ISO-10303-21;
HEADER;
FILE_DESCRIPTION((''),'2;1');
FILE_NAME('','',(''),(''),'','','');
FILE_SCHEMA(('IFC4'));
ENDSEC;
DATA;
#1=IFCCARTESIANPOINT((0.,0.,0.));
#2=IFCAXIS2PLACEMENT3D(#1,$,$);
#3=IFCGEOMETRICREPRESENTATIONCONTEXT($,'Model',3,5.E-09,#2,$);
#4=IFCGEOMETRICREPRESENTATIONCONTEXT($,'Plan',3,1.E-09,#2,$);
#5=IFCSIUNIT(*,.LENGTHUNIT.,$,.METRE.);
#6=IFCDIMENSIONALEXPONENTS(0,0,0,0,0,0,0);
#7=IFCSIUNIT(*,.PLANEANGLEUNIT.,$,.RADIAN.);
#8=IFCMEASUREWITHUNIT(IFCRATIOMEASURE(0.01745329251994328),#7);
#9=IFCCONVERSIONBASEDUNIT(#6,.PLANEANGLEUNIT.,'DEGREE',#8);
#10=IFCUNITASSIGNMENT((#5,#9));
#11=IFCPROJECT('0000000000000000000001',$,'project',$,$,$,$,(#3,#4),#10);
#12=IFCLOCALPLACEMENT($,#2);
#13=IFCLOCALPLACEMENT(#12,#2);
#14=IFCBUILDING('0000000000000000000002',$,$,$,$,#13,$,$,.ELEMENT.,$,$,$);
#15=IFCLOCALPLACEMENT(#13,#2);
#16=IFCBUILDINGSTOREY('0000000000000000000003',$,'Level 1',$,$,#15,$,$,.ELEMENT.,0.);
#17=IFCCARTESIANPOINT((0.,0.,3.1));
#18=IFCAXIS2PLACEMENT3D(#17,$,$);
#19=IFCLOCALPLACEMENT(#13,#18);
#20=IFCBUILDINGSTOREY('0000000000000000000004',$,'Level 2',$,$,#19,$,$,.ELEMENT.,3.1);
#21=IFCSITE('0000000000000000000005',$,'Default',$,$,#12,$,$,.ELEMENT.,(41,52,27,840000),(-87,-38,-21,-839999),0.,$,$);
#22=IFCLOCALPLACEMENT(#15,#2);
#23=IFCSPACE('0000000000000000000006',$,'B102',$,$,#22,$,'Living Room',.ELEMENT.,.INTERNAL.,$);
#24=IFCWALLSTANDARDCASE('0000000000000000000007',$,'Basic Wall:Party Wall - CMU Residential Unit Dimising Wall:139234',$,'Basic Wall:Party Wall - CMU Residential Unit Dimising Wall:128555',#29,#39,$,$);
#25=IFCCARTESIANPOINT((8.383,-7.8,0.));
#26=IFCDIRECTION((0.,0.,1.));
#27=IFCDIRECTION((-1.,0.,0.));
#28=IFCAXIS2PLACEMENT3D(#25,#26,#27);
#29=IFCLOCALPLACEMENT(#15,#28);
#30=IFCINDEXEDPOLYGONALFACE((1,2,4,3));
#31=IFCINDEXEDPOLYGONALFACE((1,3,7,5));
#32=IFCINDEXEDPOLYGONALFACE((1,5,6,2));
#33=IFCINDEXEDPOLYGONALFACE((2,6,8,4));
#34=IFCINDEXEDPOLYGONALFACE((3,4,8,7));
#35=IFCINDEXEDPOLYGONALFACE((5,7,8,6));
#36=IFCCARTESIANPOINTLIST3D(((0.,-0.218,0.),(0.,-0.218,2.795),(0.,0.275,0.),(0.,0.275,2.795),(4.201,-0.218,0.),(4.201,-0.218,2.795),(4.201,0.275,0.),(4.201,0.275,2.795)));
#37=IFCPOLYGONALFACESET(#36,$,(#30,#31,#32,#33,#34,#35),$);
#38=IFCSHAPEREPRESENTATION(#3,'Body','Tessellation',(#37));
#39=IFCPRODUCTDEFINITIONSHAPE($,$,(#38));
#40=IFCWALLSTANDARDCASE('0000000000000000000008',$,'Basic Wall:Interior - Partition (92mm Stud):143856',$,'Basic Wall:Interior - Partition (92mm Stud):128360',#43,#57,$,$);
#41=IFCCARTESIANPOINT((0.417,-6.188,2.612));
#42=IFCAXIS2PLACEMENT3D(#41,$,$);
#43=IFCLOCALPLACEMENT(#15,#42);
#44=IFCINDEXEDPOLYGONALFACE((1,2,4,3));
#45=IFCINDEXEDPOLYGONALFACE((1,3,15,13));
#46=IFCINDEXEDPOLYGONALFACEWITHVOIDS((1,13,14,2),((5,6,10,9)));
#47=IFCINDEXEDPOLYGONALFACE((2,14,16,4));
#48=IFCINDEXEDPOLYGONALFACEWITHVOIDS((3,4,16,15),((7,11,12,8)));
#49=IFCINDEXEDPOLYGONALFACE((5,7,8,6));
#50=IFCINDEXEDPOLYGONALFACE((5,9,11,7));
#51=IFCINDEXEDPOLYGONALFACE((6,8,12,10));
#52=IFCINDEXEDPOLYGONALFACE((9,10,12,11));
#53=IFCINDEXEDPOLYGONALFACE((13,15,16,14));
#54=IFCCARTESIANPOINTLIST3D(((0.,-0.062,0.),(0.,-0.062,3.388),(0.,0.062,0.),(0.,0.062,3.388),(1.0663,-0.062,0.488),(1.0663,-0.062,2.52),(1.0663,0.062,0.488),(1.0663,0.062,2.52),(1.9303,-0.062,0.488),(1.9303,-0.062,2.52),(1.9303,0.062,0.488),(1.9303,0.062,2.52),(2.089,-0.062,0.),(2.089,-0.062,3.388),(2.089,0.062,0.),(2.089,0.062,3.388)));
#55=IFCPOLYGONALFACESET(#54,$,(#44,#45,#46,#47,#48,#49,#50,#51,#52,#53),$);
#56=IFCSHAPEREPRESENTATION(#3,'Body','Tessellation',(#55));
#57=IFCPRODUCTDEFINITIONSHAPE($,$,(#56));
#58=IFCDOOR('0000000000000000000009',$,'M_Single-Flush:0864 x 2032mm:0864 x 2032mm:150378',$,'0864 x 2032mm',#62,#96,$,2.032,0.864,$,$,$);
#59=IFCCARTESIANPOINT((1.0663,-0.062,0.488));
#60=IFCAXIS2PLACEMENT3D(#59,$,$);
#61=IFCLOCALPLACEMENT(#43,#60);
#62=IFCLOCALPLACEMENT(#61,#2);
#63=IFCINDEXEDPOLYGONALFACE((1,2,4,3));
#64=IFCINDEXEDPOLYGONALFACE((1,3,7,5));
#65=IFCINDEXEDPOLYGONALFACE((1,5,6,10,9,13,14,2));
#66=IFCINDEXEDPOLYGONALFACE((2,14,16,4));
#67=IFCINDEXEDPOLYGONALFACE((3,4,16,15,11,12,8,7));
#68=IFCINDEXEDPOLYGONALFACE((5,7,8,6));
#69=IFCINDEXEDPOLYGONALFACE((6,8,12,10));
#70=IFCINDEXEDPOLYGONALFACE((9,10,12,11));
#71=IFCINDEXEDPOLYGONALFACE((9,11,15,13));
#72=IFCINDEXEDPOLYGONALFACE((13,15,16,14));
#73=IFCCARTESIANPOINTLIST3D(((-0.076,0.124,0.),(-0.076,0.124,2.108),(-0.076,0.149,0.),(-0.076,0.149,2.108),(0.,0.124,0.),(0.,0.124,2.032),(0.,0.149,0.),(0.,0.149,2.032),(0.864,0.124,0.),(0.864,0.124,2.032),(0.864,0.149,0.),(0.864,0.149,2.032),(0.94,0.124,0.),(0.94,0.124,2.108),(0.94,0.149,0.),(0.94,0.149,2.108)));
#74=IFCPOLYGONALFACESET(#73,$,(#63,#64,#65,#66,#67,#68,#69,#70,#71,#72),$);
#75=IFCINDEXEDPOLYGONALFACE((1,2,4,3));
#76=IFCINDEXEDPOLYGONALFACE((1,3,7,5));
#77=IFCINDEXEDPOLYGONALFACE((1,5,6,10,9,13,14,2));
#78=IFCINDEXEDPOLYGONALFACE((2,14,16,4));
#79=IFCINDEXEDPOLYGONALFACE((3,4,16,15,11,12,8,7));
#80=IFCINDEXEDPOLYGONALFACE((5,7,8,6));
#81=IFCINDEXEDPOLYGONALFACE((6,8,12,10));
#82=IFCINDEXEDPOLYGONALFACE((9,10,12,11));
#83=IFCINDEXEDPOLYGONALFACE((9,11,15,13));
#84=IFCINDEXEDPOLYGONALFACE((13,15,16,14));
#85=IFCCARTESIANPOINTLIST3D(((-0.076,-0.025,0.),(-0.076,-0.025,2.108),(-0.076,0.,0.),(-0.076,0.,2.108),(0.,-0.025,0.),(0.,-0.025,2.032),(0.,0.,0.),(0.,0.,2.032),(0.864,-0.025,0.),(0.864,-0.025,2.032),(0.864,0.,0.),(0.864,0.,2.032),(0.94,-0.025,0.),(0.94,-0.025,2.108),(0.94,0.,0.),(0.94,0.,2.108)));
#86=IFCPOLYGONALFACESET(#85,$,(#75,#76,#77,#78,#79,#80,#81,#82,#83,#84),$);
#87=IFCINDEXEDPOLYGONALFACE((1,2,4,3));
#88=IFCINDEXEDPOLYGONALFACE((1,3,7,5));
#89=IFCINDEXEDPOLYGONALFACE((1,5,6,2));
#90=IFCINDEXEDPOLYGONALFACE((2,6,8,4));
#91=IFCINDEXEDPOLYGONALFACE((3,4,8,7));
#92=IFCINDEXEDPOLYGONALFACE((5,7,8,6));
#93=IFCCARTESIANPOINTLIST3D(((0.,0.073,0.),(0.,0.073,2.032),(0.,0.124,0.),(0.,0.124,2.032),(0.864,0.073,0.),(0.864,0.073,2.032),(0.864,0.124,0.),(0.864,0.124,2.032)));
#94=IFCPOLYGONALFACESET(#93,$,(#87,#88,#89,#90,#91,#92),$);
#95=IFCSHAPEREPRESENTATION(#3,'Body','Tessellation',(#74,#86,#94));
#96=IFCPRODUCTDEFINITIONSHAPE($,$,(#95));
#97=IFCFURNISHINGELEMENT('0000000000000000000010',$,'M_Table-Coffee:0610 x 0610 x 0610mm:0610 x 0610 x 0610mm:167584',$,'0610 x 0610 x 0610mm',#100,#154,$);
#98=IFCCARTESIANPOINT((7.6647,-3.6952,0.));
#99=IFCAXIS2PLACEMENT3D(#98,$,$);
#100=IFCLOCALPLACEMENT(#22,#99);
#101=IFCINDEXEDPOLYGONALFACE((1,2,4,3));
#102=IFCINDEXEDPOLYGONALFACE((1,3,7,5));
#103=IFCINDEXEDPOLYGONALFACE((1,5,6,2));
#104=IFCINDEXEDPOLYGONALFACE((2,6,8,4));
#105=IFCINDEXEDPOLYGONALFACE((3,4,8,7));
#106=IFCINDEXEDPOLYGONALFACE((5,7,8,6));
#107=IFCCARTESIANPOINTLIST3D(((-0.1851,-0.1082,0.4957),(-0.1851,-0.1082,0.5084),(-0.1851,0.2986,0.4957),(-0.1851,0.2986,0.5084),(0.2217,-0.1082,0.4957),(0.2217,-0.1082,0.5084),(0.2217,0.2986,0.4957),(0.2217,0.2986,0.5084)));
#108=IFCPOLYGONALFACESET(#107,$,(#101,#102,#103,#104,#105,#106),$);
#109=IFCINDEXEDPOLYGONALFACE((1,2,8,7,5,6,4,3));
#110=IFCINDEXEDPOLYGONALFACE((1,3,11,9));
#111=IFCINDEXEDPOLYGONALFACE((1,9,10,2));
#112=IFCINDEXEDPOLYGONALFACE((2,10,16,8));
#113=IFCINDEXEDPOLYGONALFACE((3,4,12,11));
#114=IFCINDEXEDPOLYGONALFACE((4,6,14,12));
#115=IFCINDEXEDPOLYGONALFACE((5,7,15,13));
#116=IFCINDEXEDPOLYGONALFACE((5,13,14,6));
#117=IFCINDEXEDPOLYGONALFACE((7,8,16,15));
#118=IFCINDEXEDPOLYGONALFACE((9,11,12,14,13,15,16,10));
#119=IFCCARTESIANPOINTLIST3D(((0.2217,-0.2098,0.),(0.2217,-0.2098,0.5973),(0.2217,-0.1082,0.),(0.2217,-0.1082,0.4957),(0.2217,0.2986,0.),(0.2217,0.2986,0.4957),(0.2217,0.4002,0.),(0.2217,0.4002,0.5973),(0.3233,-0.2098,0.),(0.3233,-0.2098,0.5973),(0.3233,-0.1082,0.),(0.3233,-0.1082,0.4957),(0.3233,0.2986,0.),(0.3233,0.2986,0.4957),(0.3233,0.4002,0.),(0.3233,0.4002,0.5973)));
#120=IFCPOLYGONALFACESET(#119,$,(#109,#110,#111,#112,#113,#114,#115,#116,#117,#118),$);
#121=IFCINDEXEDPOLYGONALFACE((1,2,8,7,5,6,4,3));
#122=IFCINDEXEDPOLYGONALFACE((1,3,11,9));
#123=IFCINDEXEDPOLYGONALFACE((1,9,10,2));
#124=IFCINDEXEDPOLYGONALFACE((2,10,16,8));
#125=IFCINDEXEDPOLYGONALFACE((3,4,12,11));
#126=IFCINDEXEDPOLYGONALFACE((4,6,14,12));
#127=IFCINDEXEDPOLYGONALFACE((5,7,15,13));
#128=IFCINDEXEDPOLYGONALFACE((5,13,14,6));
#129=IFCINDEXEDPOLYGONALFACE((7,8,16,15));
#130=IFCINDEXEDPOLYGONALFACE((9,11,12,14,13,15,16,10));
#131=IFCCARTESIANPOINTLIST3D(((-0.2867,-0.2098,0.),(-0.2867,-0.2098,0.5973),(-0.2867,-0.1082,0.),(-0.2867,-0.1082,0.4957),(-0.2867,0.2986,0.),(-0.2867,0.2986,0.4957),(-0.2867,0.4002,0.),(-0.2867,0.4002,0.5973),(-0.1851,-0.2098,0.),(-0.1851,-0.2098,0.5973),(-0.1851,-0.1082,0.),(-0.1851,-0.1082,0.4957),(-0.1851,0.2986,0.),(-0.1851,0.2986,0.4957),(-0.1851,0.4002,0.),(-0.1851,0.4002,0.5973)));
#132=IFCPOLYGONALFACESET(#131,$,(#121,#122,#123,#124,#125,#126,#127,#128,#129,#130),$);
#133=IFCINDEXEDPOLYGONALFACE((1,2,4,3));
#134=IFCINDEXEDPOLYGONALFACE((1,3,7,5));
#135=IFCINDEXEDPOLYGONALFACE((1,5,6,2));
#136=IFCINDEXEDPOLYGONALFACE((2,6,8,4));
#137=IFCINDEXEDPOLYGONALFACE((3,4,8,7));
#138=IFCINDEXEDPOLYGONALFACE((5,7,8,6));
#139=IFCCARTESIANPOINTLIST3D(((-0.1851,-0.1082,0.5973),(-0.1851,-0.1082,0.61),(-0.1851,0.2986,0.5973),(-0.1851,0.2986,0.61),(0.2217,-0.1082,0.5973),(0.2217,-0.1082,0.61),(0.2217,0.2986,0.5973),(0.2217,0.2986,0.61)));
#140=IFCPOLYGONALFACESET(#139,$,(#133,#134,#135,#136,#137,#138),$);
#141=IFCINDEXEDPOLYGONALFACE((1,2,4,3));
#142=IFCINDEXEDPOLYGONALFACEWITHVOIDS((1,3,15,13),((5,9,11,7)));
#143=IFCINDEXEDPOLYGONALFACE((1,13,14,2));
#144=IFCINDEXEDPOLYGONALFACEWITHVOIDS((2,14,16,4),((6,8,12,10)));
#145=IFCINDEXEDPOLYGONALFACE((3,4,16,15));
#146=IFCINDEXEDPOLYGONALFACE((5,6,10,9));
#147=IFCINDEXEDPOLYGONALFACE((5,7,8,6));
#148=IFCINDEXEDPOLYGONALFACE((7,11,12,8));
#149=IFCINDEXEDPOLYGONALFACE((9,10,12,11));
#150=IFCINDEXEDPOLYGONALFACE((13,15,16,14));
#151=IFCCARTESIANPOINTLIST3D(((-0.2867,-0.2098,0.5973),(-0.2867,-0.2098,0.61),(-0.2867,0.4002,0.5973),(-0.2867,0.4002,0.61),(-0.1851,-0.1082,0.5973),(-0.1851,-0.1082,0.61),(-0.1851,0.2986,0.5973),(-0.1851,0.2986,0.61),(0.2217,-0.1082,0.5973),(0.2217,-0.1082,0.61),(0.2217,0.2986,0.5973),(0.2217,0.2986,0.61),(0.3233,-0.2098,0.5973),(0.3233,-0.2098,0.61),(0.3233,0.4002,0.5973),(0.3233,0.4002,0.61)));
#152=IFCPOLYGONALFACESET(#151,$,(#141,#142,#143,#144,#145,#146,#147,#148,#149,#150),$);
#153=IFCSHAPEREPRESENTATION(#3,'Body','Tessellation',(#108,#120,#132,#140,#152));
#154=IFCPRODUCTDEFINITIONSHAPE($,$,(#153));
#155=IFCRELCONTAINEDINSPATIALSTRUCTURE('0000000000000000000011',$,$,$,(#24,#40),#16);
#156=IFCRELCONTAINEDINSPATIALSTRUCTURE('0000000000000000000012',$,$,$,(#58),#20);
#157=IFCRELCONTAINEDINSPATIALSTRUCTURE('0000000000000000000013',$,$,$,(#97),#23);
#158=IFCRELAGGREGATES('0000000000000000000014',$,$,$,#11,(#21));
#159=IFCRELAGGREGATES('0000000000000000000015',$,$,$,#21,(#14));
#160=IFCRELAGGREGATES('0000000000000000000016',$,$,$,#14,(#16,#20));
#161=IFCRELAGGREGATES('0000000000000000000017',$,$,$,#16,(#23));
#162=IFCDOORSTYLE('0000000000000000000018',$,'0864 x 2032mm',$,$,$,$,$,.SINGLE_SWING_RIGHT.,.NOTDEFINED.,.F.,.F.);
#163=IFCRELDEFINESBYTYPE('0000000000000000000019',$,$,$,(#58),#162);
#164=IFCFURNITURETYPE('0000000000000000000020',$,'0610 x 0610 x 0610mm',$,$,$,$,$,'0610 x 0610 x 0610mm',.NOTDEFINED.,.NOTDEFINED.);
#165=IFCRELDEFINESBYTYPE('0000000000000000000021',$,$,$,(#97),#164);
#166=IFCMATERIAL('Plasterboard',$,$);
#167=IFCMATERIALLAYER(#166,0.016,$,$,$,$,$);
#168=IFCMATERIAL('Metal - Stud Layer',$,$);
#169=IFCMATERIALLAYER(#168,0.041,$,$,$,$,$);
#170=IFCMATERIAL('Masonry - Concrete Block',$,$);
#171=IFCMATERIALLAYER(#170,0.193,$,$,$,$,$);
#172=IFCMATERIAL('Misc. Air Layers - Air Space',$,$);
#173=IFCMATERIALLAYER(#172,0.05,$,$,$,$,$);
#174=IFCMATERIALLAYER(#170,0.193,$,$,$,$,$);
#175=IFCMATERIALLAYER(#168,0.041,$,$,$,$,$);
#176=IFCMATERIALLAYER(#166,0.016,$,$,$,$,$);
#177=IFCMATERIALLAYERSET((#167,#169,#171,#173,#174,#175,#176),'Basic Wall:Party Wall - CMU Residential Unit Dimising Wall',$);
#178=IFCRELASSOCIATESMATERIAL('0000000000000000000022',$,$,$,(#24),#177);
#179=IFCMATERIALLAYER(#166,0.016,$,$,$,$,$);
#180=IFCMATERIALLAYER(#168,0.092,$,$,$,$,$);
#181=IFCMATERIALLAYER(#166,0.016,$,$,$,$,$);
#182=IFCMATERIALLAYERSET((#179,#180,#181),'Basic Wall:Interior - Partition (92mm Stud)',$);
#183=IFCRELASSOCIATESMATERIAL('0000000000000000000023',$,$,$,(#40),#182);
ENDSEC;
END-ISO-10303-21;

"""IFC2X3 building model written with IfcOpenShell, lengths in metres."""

from ifc_helpers import new_model, entity, si_unit, converted_unit, frame, frame_2d, origin, origin_2d_with_axis, place, context, project, spatial, polyline, rectangle, outline, extrude, clip, bounded_halfspace, source, transform, mapped, material, layer, layer_set, layer_usage, type_object, type_shapes, element, fill, save


model = new_model("IFC2X3")

# Units and contexts
model_context = context("Model", 3, precision=5e-09, world=origin())
plan_context = context("Plan", 3, precision=1e-09, world=origin())
ifc_project = project(units=[si_unit("LENGTHUNIT", "METRE"), converted_unit("PLANEANGLEUNIT", "DEGREE", entity("IfcRatioMeasure", 0.01745329251994328), si_unit("PLANEANGLEUNIT", "RADIAN"), dimensions=[0, 0, 0, 0, 0, 0, 0])], contexts=[model_context, plan_context])

# Site, building, storey
site_placement = place(None, origin())
site = spatial("IfcSite", under=ifc_project, at=site_placement, Name="Default", CompositionType="ELEMENT", RefLatitude=(41, 52, 27, 840000), RefLongitude=(-87, -38, -21, -839999), RefElevation=0.0)
building_placement = place(site_placement, origin())
building = spatial("IfcBuilding", under=site, at=building_placement, CompositionType="ELEMENT")
storey_1_placement = place(building_placement, origin())
storey_1 = spatial("IfcBuildingStorey", under=building, at=storey_1_placement, Name="Level 1", CompositionType="ELEMENT", Elevation=0.0)

# Shared definitions
ifc_material_1 = material(Name="Misc. Air Layers - Air Space")
ifc_material_2 = material(Name="Masonry - Concrete Block")
ifc_material_3 = material(Name="Metal - Stud Layer")
ifc_material_4 = material(Name="Plasterboard")

# Wall
ifc_layer_1 = layer(ifc_material_4, 0.016)
ifc_layer_2 = layer(ifc_material_3, 0.041)
ifc_layer_3 = layer(ifc_material_2, 0.193)
ifc_layer_4 = layer(ifc_material_1, 0.05)
ifc_layer_5 = layer(ifc_material_2, 0.193)
ifc_layer_6 = layer(ifc_material_3, 0.041)
ifc_layer_7 = layer(ifc_material_4, 0.016)
ifc_layer_set_1 = layer_set([ifc_layer_1, ifc_layer_2, ifc_layer_3, ifc_layer_4, ifc_layer_5, ifc_layer_6, ifc_layer_7], Name="Basic Wall:Party Wall - CMU Residential Unit Dimising Wall")
ifc_layer_usage_1 = layer_usage(ifc_layer_set_1, "AXIS2", "NEGATIVE", 0.275)
wall_1_placement = place(storey_1_placement, frame((8.383, -7.8, 0.0), z_axis=(0.0, 0.0, 1.0), x_axis=(-1.0, 0.0, 0.0)))
element("IfcWallStandardCase", 1, at=wall_1_placement, inside=storey_1, material=ifc_layer_usage_1, Name="Basic Wall:Party Wall - CMU Residential Unit Dimising Wall:139234", ObjectType="Basic Wall:Party Wall - CMU Residential Unit Dimising Wall:128555", context=model_context, shape_type="Clipping", body=[
    clip(clip(extrude(rectangle(XDim=4.201, YDim=0.55, at=frame_2d((2.1005, 0.0), x_axis=(-1.0, 0.0))), origin(), (0.0, 0.0, 1.0), 2.795), bounded_halfspace(frame((0.0, -0.218, 2.795), z_axis=(0.0, 1.0, 0.0), x_axis=(-1.0, 0.0, 0.0)), True, frame((0.0, -0.218, 2.795), z_axis=(0.0, 1.0, 0.0), x_axis=(-1.0, 0.0, 0.0)), polyline([(0.0, 0.0), (-3.708, 0.0), (-4.201, 0.0), (-4.201, -2.795), (0.0, -2.795), (0.0, 0.0)]))), bounded_halfspace(frame((4.201, 0.275, 0.0), z_axis=(-1.0, 0.0, 0.0), x_axis=(0.0, -1.0, 0.0)), True, frame((4.201, 0.275, 0.0), z_axis=(-1.0, 0.0, 0.0), x_axis=(0.0, -1.0, 0.0)), polyline([(0.0, 0.0), (0.493, 0.0), (0.493, 2.795), (0.0, 2.795), (0.0, 0.0)]))),
])

# Wall, opening
ifc_layer_8 = layer(ifc_material_4, 0.016)
ifc_layer_9 = layer(ifc_material_3, 0.092)
ifc_layer_10 = layer(ifc_material_4, 0.016)
ifc_layer_set_2 = layer_set([ifc_layer_8, ifc_layer_9, ifc_layer_10], Name="Basic Wall:Interior - Partition (92mm Stud)")
ifc_layer_usage_2 = layer_usage(ifc_layer_set_2, "AXIS2", "NEGATIVE", 0.062)
wall_2_placement = place(storey_1_placement, frame((0.417, -6.188, 2.612)))
wall_2 = element("IfcWallStandardCase", 2, at=wall_2_placement, inside=storey_1, material=ifc_layer_usage_2, Name="Basic Wall:Interior - Partition (92mm Stud):143856", ObjectType="Basic Wall:Interior - Partition (92mm Stud):128360", context=model_context, shape_type="SweptSolid", body=[
    extrude(rectangle(XDim=2.089, YDim=0.124, at=frame_2d((1.0445, 0.0), x_axis=(-1.0, 0.0))), origin(), (0.0, 0.0, 1.0), 3.388),
])
opening_1_placement = place(wall_2_placement, frame((1.0663, -0.062, 0.488)))
opening_1 = element("IfcOpeningElement", 3, at=opening_1_placement, cuts=wall_2, ObjectType="Opening", context=model_context, shape_type="SweptSolid", body=[
    extrude(rectangle(XDim=0.864, YDim=2.032, at=frame_2d((1.016, 0.432), x_axis=(0.0, 1.0))), frame((0.0, 0.0, 0.0), z_axis=(0.0, 1.0, 0.0), x_axis=(0.0, 0.0, 1.0)), (0.0, 0.0, 1.0), 0.124),
])

# Shared definitions
storey_2_placement = place(building_placement, frame((0.0, 0.0, 3.1)))
storey_2 = spatial("IfcBuildingStorey", under=building, at=storey_2_placement, Name="Level 2", CompositionType="ELEMENT", Elevation=3.1)

# Door
door_style_1 = type_object("IfcDoorStyle", Name="0864 x 2032mm", ConstructionType="NOTDEFINED", OperationType="SINGLE_SWING_RIGHT", ParameterTakesPrecedence=False, Sizeable=False)
shared_shape_1 = source(origin(), model_context, "Body", "SweptSolid", [
    extrude(outline(polyline([(-0.508, -1.073), (0.508, -1.073), (0.508, 1.035), (0.432, 1.035), (0.432, -0.997), (-0.432, -0.997), (-0.432, 1.035), (-0.508, 1.035), (-0.508, -1.073)])), frame((0.432, 0.124, 1.035), z_axis=(0.0, 1.0, 0.0), x_axis=(1.0, 0.0, 0.0)), (0.0, 0.0, 1.0), 0.025),
    extrude(outline(polyline([(-1.073, -0.508), (1.035, -0.508), (1.035, -0.432), (-0.997, -0.432), (-0.997, 0.432), (1.035, 0.432), (1.035, 0.508), (-1.073, 0.508), (-1.073, -0.508)])), frame((0.432, -0.025, 1.035), z_axis=(0.0, 1.0, 0.0), x_axis=(0.0, 0.0, -1.0)), (0.0, 0.0, 1.0), 0.025),
    extrude(rectangle(XDim=0.051, YDim=0.864, at=origin_2d_with_axis()), frame((0.432, 0.0985, 0.0), z_axis=(0.0, 0.0, 1.0), x_axis=(0.0, 1.0, 0.0)), (0.0, 0.0, 1.0), 2.032),
])
type_shapes(door_style_1, [shared_shape_1])
door_1_placement = place(opening_1_placement, origin())
door_1 = element("IfcDoor", 4, at=door_1_placement, inside=storey_2, type_object=door_style_1, Name="M_Single-Flush:0864 x 2032mm:0864 x 2032mm:150378", ObjectType="0864 x 2032mm", OverallHeight=2.032, OverallWidth=0.864, context=model_context, shape_type="MappedRepresentation", body=[
    mapped(shared_shape_1, transform((0.0, 0.0, 0.0), scale=1.0)),
])
fill(opening_1, door_1)

# Shared definitions
space_1_placement = place(storey_1_placement, origin())
space_1 = spatial("IfcSpace", under=storey_1, at=space_1_placement, Name="B102", LongName="Living Room", CompositionType="ELEMENT", InteriorOrExteriorSpace="INTERNAL")

# Furnishing element
furniture_type_1 = type_object("IfcFurnitureType", Name="0610 x 0610 x 0610mm", ElementType="0610 x 0610 x 0610mm", AssemblyPlace="NOTDEFINED")
shared_shape_2 = source(origin(), model_context, "Body", "SweptSolid", [
    extrude(rectangle(XDim=0.4068, YDim=0.4068, at=origin_2d_with_axis()), frame((0.0183, 0.0952, 0.4957), z_axis=(0.0, 0.0, 1.0), x_axis=(-1.0, 0.0, 0.0)), (0.0, 0.0, 1.0), 0.0127),
    extrude(outline(polyline([(-0.2732, -0.305), (0.324, -0.305), (0.324, 0.305), (-0.2732, 0.305), (-0.2732, 0.2034), (0.2225, 0.2034), (0.2225, -0.2034), (-0.2732, -0.2034), (-0.2732, -0.305)])), frame((0.2217, 0.0952, 0.2732), z_axis=(1.0, 0.0, 0.0), x_axis=(0.0, 0.0, 1.0)), (0.0, 0.0, 1.0), 0.1016),
    extrude(outline(polyline([(-0.305, -0.3241), (0.305, -0.3241), (0.305, 0.2733), (0.2034, 0.2733), (0.2034, -0.2224), (-0.2034, -0.2224), (-0.2034, 0.2733), (-0.305, 0.2733), (-0.305, -0.3241)])), frame((-0.2867, 0.0952, 0.2733), z_axis=(1.0, 0.0, 0.0), x_axis=(0.0, -1.0, 0.0)), (0.0, 0.0, 1.0), 0.1016),
    extrude(rectangle(XDim=0.4068, YDim=0.4068, at=origin_2d_with_axis()), frame((0.0183, 0.0952, 0.5973), z_axis=(0.0, 0.0, 1.0), x_axis=(-1.0, 0.0, 0.0)), (0.0, 0.0, 1.0), 0.0127),
    extrude(outline(polyline([(-0.305, -0.305), (0.305, -0.305), (0.305, 0.305), (-0.305, 0.305), (-0.305, -0.305)]), holes=[polyline([(-0.2034, -0.2034), (-0.2034, 0.2034), (0.2034, 0.2034), (0.2034, -0.2034), (-0.2034, -0.2034)])]), frame((0.0183, 0.0952, 0.5973), z_axis=(0.0, 0.0, 1.0), x_axis=(-1.0, 0.0, 0.0)), (0.0, 0.0, 1.0), 0.0127),
])
type_shapes(furniture_type_1, [shared_shape_2])
for number, where, name in (
    (5, (7.6647, -3.6952, 0.0), "M_Table-Coffee:0610 x 0610 x 0610mm:0610 x 0610 x 0610mm:167584"),
):
    element("IfcFurnishingElement", number, at=place(space_1_placement, frame(where)), inside=space_1, type_object=furniture_type_1, Name=name, ObjectType="0610 x 0610 x 0610mm", context=model_context, shape_type="MappedRepresentation", body=[
        mapped(shared_shape_2, transform((0.0, 0.0, 0.0), scale=1.0)),
    ])

save(model, "model.ifc")
